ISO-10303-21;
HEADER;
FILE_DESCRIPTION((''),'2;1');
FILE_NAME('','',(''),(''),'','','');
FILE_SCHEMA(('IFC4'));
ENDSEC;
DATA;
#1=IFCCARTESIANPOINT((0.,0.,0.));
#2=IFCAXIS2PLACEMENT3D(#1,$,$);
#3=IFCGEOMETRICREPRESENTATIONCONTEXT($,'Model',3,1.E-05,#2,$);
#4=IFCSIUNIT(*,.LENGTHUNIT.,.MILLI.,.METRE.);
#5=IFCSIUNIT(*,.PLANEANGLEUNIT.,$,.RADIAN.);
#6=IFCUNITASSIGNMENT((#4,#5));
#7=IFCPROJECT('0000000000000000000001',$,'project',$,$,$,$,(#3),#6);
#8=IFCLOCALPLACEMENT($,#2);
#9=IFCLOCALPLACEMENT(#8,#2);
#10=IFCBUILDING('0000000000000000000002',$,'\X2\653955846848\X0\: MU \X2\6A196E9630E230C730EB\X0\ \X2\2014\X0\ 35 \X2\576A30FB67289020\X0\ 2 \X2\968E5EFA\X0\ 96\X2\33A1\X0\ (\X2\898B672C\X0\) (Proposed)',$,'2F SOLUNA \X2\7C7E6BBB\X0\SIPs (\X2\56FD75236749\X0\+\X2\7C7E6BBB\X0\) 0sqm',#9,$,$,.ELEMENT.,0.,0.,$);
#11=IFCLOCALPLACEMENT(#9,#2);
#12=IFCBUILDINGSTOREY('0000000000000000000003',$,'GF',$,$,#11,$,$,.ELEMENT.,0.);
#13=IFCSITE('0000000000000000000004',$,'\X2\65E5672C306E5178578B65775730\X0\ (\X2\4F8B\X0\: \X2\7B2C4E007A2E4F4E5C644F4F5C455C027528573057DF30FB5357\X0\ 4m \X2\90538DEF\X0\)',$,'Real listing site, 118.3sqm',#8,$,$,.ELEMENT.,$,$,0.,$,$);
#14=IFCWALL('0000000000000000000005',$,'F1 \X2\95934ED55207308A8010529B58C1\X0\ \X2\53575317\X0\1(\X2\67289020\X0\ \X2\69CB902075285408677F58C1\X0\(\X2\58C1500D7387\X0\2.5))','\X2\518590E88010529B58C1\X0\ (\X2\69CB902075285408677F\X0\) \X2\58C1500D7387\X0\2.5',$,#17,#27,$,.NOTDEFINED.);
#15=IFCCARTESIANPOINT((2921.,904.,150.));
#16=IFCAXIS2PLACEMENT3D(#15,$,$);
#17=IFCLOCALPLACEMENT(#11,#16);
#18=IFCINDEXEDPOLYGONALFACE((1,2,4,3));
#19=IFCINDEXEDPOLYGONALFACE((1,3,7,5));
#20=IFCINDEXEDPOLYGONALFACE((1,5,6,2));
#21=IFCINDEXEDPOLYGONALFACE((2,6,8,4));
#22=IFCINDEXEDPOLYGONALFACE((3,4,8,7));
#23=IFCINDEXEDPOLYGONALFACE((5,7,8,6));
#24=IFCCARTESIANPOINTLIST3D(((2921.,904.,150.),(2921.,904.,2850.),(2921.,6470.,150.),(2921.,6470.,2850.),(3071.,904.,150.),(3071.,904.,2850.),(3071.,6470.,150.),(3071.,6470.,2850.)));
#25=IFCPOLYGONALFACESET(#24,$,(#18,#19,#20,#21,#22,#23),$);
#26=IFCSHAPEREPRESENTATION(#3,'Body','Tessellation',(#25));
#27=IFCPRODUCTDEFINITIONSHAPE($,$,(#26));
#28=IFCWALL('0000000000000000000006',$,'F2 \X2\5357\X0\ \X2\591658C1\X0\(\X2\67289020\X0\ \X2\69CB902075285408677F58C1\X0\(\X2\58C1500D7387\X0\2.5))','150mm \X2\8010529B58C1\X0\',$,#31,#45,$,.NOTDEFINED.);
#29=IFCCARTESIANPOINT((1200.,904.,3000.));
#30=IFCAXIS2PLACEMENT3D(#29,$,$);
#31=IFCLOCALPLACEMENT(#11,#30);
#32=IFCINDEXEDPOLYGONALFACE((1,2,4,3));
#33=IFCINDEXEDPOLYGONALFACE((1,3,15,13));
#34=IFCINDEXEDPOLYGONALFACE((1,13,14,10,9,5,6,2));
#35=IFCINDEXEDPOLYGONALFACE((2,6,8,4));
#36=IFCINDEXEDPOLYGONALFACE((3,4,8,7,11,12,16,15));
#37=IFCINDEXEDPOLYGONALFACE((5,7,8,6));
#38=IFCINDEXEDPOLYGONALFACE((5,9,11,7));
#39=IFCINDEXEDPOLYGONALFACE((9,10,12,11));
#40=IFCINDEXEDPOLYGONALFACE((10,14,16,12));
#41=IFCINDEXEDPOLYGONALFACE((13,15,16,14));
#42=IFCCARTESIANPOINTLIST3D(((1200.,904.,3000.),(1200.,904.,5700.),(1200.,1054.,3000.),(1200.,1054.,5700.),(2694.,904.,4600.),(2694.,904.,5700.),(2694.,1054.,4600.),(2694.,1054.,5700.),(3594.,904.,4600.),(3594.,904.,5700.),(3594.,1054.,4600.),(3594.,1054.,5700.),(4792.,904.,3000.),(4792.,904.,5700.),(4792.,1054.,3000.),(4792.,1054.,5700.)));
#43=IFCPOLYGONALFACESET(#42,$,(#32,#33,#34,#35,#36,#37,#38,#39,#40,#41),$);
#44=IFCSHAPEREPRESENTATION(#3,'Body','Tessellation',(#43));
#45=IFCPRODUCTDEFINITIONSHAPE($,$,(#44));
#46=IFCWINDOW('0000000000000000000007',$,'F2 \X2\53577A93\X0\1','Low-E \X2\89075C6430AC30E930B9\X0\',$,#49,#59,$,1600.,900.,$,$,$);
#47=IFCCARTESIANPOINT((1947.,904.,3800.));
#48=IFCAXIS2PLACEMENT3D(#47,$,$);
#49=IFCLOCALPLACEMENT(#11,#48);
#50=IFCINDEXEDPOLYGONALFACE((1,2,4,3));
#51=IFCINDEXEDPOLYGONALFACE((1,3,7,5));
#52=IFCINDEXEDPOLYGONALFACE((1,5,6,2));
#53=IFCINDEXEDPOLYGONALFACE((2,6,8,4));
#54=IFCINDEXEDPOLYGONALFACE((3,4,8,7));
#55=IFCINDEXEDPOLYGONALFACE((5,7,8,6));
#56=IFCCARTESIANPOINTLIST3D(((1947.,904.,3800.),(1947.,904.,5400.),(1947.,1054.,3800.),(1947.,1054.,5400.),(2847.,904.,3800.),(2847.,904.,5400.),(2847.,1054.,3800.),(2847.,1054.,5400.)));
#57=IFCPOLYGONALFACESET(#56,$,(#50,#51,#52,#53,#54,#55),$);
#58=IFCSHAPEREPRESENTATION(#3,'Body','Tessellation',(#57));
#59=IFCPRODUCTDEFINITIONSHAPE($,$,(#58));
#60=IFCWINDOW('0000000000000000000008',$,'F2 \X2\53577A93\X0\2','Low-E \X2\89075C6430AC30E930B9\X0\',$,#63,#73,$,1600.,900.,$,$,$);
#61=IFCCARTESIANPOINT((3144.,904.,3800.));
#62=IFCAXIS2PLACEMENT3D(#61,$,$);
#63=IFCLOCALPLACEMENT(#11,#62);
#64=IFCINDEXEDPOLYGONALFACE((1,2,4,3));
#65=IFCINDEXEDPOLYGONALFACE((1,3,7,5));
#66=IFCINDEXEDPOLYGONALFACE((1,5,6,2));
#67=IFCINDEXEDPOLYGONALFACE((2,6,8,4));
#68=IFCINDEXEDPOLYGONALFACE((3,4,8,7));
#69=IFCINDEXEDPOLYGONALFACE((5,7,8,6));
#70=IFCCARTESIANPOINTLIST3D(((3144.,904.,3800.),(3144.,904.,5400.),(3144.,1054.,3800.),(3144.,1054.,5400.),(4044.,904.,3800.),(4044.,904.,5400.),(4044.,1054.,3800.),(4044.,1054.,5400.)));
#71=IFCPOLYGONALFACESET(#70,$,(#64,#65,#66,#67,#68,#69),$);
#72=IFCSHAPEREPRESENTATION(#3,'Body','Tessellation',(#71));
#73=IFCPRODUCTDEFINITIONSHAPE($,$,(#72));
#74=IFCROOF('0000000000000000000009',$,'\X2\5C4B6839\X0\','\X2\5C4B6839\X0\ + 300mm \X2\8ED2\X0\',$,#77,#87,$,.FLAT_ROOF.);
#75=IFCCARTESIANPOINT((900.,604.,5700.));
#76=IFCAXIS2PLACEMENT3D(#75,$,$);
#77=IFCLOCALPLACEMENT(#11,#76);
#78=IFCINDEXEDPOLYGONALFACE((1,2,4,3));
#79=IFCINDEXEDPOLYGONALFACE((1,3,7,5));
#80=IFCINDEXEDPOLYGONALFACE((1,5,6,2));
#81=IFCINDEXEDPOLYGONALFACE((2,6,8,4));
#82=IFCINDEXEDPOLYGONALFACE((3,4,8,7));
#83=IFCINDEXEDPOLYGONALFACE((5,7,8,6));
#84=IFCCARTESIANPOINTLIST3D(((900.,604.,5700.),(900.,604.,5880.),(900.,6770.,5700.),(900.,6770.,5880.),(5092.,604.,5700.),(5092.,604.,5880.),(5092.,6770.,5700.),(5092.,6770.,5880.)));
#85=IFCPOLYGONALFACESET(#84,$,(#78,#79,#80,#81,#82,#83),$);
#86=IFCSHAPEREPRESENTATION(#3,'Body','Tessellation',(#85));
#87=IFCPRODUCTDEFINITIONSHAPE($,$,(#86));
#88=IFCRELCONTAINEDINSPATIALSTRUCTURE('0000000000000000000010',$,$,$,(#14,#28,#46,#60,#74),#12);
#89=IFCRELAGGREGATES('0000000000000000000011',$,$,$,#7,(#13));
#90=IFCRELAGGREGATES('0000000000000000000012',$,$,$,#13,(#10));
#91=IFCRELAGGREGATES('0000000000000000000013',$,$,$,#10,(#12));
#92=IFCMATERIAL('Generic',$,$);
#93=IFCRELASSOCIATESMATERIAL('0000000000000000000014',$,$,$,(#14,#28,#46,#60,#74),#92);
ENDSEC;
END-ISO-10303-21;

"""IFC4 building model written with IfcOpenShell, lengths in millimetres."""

from ifc_helpers import new_model, si_unit, frame, frame_2d, origin, place, context, project, spatial, rectangle, extrude, material, element, fill, save


model = new_model("IFC4")

# Units and contexts
model_context = context("Model", 3, precision=1e-05, world=origin())
ifc_project = project(units=[si_unit("LENGTHUNIT", "METRE", prefix="MILLI"), si_unit("PLANEANGLEUNIT", "RADIAN")], contexts=[model_context])

# Site, building, storey
site_placement = place(None, origin())
site = spatial("IfcSite", under=ifc_project, at=site_placement, Name="日本の典型敷地 (例: 第一種低層住居専用地域・南 4m 道路)", ObjectType="Real listing site, 118.3sqm", CompositionType="ELEMENT", RefElevation=0.0)
building_placement = place(site_placement, origin())
building = spatial("IfcBuilding", under=site, at=building_placement, Name="改善案: MU 標準モデル — 35 坪・木造 2 階建 96㎡ (見本) (Proposed)", ObjectType="2F SOLUNA 籾殻SIPs (国産杉+籾殻) 0sqm", CompositionType="ELEMENT", ElevationOfRefHeight=0.0, ElevationOfTerrain=0.0)
storey_placement = place(building_placement, origin())
storey = spatial("IfcBuildingStorey", under=building, at=storey_placement, Name="GF", CompositionType="ELEMENT", Elevation=0.0)

# Shared definitions
ifc_material_1 = material(Name="Generic")

# Wall
wall_1_placement = place(storey_placement, frame((2921.0, 904.0, 150.0)))
element("IfcWall", 1, at=wall_1_placement, inside=storey, material=ifc_material_1, Name="F1 間仕切り耐力壁 南北1(木造 構造用合板壁(壁倍率2.5))", Description="内部耐力壁 (構造用合板) 壁倍率2.5", PredefinedType="NOTDEFINED", context=model_context, shape_type="SweptSolid", body=[
    extrude(rectangle(XDim=150.0, YDim=5566.0, at=frame_2d((75.0, 2783.0))), frame((2921.0, 904.0, 150.0)), (0.0, 0.0, 1.0), 2700.0),
])

# Wall, openings, windows
wall_2_placement = place(storey_placement, frame((1200.0, 904.0, 3000.0)))
wall_2 = element("IfcWall", 2, at=wall_2_placement, inside=storey, material=ifc_material_1, Name="F2 南 外壁(木造 構造用合板壁(壁倍率2.5))", Description="150mm 耐力壁", PredefinedType="NOTDEFINED", context=model_context, shape_type="SweptSolid", body=[
    extrude(rectangle(XDim=3592.0, YDim=150.0, at=frame_2d((1796.0, 75.0))), frame((1200.0, 904.0, 3000.0)), (0.0, 0.0, 1.0), 2700.0),
])
opening_1_placement = place(storey_placement, frame((1947.0, 904.0, 3800.0)))
opening_1 = element("IfcOpeningElement", 3, at=opening_1_placement, cuts=wall_2, PredefinedType="NOTDEFINED", context=model_context, shape_type="SweptSolid", body=[
    extrude(rectangle(XDim=900.0, YDim=150.0, at=frame_2d((450.0, 75.0))), frame((1947.0, 904.0, 3800.0)), (0.0, 0.0, 1.0), 1600.0),
])
opening_2_placement = place(storey_placement, frame((3144.0, 904.0, 3800.0)))
opening_2 = element("IfcOpeningElement", 4, at=opening_2_placement, cuts=wall_2, PredefinedType="NOTDEFINED", context=model_context, shape_type="SweptSolid", body=[
    extrude(rectangle(XDim=900.0, YDim=150.0, at=frame_2d((450.0, 75.0))), frame((3144.0, 904.0, 3800.0)), (0.0, 0.0, 1.0), 1600.0),
])
window_1_placement = place(storey_placement, frame((1947.0, 904.0, 3800.0)))
window_1 = element("IfcWindow", 5, at=window_1_placement, inside=storey, material=ifc_material_1, Name="F2 南窓1", Description="Low-E 複層ガラス", OverallHeight=1600.0, OverallWidth=900.0, context=model_context, shape_type="SweptSolid", body=[
    extrude(rectangle(XDim=900.0, YDim=150.0, at=frame_2d((450.0, 75.0))), frame((1947.0, 904.0, 3800.0)), (0.0, 0.0, 1.0), 1600.0),
])
fill(opening_1, window_1)
window_2_placement = place(storey_placement, frame((3144.0, 904.0, 3800.0)))
window_2 = element("IfcWindow", 6, at=window_2_placement, inside=storey, material=ifc_material_1, Name="F2 南窓2", Description="Low-E 複層ガラス", OverallHeight=1600.0, OverallWidth=900.0, context=model_context, shape_type="SweptSolid", body=[
    extrude(rectangle(XDim=900.0, YDim=150.0, at=frame_2d((450.0, 75.0))), frame((3144.0, 904.0, 3800.0)), (0.0, 0.0, 1.0), 1600.0),
])
fill(opening_2, window_2)

# Roof
roof_placement = place(storey_placement, frame((900.0, 604.0, 5700.0)))
element("IfcRoof", 7, at=roof_placement, inside=storey, material=ifc_material_1, Name="屋根", Description="屋根 + 300mm 軒", PredefinedType="FLAT_ROOF", context=model_context, shape_type="SweptSolid", body=[
    extrude(rectangle(XDim=4192.0, YDim=6166.0, at=frame_2d((2096.0, 3083.0))), frame((900.0, 604.0, 5700.0)), (0.0, 0.0, 1.0), 180.0),
])

save(model, "model.ifc")
